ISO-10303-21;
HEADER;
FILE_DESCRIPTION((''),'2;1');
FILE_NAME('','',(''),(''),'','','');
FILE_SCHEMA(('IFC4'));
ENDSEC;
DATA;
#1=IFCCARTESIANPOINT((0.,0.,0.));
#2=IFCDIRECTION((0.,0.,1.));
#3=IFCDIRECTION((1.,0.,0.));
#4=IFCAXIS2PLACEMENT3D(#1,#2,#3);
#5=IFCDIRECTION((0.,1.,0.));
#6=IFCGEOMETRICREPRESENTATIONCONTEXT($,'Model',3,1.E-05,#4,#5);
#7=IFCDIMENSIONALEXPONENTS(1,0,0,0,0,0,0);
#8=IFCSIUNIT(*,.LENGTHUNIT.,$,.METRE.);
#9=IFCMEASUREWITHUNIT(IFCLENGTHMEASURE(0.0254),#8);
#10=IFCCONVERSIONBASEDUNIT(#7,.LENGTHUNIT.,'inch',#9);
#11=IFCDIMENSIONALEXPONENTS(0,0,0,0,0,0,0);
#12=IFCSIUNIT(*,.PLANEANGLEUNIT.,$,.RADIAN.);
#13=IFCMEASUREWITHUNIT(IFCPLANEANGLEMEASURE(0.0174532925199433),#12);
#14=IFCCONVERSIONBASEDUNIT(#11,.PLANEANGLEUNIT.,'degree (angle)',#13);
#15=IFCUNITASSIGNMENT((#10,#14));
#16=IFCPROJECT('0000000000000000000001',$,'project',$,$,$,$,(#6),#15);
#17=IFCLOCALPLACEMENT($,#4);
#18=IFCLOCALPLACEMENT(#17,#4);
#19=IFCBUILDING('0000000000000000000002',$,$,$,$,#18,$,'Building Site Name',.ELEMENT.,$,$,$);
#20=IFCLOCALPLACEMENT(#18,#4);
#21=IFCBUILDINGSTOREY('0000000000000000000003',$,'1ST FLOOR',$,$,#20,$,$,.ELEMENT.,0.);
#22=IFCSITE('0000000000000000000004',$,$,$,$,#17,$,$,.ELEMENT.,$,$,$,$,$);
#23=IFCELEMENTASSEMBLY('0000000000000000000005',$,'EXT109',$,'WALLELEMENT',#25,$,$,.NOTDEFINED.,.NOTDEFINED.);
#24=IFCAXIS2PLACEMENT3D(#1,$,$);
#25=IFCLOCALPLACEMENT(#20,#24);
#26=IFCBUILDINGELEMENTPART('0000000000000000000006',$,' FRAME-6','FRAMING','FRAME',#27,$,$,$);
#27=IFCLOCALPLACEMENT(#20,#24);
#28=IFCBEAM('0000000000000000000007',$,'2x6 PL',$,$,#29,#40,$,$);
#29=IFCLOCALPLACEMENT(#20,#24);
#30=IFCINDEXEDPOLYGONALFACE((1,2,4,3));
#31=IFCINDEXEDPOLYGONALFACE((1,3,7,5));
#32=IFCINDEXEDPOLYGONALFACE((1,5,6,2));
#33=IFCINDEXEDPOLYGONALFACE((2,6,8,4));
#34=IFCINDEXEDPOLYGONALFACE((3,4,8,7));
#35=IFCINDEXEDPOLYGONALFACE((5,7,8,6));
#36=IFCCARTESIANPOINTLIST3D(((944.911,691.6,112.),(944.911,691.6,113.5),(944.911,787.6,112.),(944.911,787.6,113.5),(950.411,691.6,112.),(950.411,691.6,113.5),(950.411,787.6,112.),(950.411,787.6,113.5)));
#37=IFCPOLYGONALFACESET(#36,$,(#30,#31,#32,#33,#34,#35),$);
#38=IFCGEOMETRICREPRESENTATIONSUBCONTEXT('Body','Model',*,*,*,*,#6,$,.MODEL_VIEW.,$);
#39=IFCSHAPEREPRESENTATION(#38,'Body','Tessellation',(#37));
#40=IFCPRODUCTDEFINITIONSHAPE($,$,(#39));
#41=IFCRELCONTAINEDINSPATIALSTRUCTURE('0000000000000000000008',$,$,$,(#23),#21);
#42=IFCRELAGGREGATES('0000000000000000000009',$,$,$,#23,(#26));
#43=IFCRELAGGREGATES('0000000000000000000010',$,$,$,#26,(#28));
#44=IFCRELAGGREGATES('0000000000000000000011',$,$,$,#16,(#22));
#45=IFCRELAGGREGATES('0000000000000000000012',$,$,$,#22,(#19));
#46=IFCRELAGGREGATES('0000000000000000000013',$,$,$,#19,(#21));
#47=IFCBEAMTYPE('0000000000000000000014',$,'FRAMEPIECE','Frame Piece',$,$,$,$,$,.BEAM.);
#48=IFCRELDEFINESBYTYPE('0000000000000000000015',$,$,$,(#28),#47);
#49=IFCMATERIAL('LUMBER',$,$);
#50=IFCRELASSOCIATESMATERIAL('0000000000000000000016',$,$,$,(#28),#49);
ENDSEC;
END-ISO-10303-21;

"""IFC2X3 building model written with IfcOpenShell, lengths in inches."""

from ifc_helpers import new_model, entity, si_unit, converted_unit, direction, frame, frame_2d, origin_with_axes, place, context, subcontext, project, spatial, rectangle, extrude, material, type_object, element, aggregate, save


model = new_model("IFC2X3")

# Units and contexts
model_context = context("Model", 3, precision=1e-05, world=origin_with_axes(), true_north=direction((0.0, 1.0, 0.0)))
body_context = subcontext(model_context, "Body", "Model", "MODEL_VIEW")
ifc_project = project(units=[converted_unit("LENGTHUNIT", "inch", entity("IfcLengthMeasure", 0.0254), si_unit("LENGTHUNIT", "METRE"), dimensions=[1, 0, 0, 0, 0, 0, 0]), converted_unit("PLANEANGLEUNIT", "degree (angle)", entity("IfcPlaneAngleMeasure", 0.0174532925199433), si_unit("PLANEANGLEUNIT", "RADIAN"), dimensions=[0, 0, 0, 0, 0, 0, 0])], contexts=[model_context])

# Site, building, storey
site_placement = place(None, origin_with_axes())
site = spatial("IfcSite", under=ifc_project, at=site_placement, CompositionType="ELEMENT")
building_placement = place(site_placement, origin_with_axes())
building = spatial("IfcBuilding", under=site, at=building_placement, LongName="Building Site Name", CompositionType="ELEMENT")
storey_placement = place(building_placement, origin_with_axes())
storey = spatial("IfcBuildingStorey", under=building, at=storey_placement, Name="1ST FLOOR", CompositionType="ELEMENT", Elevation=0.0)

# Element assembly, building element part
ifc_material_1 = material(Name="LUMBER")
beam_type = type_object("IfcBeamType", Name="FRAMEPIECE", Description="Frame Piece", PredefinedType="BEAM")
assembly_1_placement = place(storey_placement, origin_with_axes())
assembly_1 = element("IfcElementAssembly", 1, at=assembly_1_placement, inside=storey, Name="EXT109", ObjectType="WALLELEMENT", AssemblyPlace="NOTDEFINED", PredefinedType="NOTDEFINED")
building_element_part_1 = element("IfcBuildingElementPart", 2, Name=" FRAME-6", Description="FRAMING", ObjectType="FRAME")
aggregate(assembly_1, [building_element_part_1])

# Beam
beam_1_placement = place(assembly_1_placement, frame((947.661, 691.6, 112.75), z_axis=(0.0, 1.0, 0.0), x_axis=(0.0, 0.0, -1.0)))
beam_1 = element("IfcBeam", 3, at=beam_1_placement, type_object=beam_type, material=ifc_material_1, Name="2x6 PL", context=body_context, shape_type="SweptSolid", body=[
    extrude(rectangle(XDim=1.5, YDim=5.5, at=frame_2d((0.0, 0.0), x_axis=(-1.0, 0.0))), origin_with_axes(), (0.0, 0.0, 1.0), 96.0),
])
aggregate(building_element_part_1, [beam_1])

save(model, "model.ifc")
